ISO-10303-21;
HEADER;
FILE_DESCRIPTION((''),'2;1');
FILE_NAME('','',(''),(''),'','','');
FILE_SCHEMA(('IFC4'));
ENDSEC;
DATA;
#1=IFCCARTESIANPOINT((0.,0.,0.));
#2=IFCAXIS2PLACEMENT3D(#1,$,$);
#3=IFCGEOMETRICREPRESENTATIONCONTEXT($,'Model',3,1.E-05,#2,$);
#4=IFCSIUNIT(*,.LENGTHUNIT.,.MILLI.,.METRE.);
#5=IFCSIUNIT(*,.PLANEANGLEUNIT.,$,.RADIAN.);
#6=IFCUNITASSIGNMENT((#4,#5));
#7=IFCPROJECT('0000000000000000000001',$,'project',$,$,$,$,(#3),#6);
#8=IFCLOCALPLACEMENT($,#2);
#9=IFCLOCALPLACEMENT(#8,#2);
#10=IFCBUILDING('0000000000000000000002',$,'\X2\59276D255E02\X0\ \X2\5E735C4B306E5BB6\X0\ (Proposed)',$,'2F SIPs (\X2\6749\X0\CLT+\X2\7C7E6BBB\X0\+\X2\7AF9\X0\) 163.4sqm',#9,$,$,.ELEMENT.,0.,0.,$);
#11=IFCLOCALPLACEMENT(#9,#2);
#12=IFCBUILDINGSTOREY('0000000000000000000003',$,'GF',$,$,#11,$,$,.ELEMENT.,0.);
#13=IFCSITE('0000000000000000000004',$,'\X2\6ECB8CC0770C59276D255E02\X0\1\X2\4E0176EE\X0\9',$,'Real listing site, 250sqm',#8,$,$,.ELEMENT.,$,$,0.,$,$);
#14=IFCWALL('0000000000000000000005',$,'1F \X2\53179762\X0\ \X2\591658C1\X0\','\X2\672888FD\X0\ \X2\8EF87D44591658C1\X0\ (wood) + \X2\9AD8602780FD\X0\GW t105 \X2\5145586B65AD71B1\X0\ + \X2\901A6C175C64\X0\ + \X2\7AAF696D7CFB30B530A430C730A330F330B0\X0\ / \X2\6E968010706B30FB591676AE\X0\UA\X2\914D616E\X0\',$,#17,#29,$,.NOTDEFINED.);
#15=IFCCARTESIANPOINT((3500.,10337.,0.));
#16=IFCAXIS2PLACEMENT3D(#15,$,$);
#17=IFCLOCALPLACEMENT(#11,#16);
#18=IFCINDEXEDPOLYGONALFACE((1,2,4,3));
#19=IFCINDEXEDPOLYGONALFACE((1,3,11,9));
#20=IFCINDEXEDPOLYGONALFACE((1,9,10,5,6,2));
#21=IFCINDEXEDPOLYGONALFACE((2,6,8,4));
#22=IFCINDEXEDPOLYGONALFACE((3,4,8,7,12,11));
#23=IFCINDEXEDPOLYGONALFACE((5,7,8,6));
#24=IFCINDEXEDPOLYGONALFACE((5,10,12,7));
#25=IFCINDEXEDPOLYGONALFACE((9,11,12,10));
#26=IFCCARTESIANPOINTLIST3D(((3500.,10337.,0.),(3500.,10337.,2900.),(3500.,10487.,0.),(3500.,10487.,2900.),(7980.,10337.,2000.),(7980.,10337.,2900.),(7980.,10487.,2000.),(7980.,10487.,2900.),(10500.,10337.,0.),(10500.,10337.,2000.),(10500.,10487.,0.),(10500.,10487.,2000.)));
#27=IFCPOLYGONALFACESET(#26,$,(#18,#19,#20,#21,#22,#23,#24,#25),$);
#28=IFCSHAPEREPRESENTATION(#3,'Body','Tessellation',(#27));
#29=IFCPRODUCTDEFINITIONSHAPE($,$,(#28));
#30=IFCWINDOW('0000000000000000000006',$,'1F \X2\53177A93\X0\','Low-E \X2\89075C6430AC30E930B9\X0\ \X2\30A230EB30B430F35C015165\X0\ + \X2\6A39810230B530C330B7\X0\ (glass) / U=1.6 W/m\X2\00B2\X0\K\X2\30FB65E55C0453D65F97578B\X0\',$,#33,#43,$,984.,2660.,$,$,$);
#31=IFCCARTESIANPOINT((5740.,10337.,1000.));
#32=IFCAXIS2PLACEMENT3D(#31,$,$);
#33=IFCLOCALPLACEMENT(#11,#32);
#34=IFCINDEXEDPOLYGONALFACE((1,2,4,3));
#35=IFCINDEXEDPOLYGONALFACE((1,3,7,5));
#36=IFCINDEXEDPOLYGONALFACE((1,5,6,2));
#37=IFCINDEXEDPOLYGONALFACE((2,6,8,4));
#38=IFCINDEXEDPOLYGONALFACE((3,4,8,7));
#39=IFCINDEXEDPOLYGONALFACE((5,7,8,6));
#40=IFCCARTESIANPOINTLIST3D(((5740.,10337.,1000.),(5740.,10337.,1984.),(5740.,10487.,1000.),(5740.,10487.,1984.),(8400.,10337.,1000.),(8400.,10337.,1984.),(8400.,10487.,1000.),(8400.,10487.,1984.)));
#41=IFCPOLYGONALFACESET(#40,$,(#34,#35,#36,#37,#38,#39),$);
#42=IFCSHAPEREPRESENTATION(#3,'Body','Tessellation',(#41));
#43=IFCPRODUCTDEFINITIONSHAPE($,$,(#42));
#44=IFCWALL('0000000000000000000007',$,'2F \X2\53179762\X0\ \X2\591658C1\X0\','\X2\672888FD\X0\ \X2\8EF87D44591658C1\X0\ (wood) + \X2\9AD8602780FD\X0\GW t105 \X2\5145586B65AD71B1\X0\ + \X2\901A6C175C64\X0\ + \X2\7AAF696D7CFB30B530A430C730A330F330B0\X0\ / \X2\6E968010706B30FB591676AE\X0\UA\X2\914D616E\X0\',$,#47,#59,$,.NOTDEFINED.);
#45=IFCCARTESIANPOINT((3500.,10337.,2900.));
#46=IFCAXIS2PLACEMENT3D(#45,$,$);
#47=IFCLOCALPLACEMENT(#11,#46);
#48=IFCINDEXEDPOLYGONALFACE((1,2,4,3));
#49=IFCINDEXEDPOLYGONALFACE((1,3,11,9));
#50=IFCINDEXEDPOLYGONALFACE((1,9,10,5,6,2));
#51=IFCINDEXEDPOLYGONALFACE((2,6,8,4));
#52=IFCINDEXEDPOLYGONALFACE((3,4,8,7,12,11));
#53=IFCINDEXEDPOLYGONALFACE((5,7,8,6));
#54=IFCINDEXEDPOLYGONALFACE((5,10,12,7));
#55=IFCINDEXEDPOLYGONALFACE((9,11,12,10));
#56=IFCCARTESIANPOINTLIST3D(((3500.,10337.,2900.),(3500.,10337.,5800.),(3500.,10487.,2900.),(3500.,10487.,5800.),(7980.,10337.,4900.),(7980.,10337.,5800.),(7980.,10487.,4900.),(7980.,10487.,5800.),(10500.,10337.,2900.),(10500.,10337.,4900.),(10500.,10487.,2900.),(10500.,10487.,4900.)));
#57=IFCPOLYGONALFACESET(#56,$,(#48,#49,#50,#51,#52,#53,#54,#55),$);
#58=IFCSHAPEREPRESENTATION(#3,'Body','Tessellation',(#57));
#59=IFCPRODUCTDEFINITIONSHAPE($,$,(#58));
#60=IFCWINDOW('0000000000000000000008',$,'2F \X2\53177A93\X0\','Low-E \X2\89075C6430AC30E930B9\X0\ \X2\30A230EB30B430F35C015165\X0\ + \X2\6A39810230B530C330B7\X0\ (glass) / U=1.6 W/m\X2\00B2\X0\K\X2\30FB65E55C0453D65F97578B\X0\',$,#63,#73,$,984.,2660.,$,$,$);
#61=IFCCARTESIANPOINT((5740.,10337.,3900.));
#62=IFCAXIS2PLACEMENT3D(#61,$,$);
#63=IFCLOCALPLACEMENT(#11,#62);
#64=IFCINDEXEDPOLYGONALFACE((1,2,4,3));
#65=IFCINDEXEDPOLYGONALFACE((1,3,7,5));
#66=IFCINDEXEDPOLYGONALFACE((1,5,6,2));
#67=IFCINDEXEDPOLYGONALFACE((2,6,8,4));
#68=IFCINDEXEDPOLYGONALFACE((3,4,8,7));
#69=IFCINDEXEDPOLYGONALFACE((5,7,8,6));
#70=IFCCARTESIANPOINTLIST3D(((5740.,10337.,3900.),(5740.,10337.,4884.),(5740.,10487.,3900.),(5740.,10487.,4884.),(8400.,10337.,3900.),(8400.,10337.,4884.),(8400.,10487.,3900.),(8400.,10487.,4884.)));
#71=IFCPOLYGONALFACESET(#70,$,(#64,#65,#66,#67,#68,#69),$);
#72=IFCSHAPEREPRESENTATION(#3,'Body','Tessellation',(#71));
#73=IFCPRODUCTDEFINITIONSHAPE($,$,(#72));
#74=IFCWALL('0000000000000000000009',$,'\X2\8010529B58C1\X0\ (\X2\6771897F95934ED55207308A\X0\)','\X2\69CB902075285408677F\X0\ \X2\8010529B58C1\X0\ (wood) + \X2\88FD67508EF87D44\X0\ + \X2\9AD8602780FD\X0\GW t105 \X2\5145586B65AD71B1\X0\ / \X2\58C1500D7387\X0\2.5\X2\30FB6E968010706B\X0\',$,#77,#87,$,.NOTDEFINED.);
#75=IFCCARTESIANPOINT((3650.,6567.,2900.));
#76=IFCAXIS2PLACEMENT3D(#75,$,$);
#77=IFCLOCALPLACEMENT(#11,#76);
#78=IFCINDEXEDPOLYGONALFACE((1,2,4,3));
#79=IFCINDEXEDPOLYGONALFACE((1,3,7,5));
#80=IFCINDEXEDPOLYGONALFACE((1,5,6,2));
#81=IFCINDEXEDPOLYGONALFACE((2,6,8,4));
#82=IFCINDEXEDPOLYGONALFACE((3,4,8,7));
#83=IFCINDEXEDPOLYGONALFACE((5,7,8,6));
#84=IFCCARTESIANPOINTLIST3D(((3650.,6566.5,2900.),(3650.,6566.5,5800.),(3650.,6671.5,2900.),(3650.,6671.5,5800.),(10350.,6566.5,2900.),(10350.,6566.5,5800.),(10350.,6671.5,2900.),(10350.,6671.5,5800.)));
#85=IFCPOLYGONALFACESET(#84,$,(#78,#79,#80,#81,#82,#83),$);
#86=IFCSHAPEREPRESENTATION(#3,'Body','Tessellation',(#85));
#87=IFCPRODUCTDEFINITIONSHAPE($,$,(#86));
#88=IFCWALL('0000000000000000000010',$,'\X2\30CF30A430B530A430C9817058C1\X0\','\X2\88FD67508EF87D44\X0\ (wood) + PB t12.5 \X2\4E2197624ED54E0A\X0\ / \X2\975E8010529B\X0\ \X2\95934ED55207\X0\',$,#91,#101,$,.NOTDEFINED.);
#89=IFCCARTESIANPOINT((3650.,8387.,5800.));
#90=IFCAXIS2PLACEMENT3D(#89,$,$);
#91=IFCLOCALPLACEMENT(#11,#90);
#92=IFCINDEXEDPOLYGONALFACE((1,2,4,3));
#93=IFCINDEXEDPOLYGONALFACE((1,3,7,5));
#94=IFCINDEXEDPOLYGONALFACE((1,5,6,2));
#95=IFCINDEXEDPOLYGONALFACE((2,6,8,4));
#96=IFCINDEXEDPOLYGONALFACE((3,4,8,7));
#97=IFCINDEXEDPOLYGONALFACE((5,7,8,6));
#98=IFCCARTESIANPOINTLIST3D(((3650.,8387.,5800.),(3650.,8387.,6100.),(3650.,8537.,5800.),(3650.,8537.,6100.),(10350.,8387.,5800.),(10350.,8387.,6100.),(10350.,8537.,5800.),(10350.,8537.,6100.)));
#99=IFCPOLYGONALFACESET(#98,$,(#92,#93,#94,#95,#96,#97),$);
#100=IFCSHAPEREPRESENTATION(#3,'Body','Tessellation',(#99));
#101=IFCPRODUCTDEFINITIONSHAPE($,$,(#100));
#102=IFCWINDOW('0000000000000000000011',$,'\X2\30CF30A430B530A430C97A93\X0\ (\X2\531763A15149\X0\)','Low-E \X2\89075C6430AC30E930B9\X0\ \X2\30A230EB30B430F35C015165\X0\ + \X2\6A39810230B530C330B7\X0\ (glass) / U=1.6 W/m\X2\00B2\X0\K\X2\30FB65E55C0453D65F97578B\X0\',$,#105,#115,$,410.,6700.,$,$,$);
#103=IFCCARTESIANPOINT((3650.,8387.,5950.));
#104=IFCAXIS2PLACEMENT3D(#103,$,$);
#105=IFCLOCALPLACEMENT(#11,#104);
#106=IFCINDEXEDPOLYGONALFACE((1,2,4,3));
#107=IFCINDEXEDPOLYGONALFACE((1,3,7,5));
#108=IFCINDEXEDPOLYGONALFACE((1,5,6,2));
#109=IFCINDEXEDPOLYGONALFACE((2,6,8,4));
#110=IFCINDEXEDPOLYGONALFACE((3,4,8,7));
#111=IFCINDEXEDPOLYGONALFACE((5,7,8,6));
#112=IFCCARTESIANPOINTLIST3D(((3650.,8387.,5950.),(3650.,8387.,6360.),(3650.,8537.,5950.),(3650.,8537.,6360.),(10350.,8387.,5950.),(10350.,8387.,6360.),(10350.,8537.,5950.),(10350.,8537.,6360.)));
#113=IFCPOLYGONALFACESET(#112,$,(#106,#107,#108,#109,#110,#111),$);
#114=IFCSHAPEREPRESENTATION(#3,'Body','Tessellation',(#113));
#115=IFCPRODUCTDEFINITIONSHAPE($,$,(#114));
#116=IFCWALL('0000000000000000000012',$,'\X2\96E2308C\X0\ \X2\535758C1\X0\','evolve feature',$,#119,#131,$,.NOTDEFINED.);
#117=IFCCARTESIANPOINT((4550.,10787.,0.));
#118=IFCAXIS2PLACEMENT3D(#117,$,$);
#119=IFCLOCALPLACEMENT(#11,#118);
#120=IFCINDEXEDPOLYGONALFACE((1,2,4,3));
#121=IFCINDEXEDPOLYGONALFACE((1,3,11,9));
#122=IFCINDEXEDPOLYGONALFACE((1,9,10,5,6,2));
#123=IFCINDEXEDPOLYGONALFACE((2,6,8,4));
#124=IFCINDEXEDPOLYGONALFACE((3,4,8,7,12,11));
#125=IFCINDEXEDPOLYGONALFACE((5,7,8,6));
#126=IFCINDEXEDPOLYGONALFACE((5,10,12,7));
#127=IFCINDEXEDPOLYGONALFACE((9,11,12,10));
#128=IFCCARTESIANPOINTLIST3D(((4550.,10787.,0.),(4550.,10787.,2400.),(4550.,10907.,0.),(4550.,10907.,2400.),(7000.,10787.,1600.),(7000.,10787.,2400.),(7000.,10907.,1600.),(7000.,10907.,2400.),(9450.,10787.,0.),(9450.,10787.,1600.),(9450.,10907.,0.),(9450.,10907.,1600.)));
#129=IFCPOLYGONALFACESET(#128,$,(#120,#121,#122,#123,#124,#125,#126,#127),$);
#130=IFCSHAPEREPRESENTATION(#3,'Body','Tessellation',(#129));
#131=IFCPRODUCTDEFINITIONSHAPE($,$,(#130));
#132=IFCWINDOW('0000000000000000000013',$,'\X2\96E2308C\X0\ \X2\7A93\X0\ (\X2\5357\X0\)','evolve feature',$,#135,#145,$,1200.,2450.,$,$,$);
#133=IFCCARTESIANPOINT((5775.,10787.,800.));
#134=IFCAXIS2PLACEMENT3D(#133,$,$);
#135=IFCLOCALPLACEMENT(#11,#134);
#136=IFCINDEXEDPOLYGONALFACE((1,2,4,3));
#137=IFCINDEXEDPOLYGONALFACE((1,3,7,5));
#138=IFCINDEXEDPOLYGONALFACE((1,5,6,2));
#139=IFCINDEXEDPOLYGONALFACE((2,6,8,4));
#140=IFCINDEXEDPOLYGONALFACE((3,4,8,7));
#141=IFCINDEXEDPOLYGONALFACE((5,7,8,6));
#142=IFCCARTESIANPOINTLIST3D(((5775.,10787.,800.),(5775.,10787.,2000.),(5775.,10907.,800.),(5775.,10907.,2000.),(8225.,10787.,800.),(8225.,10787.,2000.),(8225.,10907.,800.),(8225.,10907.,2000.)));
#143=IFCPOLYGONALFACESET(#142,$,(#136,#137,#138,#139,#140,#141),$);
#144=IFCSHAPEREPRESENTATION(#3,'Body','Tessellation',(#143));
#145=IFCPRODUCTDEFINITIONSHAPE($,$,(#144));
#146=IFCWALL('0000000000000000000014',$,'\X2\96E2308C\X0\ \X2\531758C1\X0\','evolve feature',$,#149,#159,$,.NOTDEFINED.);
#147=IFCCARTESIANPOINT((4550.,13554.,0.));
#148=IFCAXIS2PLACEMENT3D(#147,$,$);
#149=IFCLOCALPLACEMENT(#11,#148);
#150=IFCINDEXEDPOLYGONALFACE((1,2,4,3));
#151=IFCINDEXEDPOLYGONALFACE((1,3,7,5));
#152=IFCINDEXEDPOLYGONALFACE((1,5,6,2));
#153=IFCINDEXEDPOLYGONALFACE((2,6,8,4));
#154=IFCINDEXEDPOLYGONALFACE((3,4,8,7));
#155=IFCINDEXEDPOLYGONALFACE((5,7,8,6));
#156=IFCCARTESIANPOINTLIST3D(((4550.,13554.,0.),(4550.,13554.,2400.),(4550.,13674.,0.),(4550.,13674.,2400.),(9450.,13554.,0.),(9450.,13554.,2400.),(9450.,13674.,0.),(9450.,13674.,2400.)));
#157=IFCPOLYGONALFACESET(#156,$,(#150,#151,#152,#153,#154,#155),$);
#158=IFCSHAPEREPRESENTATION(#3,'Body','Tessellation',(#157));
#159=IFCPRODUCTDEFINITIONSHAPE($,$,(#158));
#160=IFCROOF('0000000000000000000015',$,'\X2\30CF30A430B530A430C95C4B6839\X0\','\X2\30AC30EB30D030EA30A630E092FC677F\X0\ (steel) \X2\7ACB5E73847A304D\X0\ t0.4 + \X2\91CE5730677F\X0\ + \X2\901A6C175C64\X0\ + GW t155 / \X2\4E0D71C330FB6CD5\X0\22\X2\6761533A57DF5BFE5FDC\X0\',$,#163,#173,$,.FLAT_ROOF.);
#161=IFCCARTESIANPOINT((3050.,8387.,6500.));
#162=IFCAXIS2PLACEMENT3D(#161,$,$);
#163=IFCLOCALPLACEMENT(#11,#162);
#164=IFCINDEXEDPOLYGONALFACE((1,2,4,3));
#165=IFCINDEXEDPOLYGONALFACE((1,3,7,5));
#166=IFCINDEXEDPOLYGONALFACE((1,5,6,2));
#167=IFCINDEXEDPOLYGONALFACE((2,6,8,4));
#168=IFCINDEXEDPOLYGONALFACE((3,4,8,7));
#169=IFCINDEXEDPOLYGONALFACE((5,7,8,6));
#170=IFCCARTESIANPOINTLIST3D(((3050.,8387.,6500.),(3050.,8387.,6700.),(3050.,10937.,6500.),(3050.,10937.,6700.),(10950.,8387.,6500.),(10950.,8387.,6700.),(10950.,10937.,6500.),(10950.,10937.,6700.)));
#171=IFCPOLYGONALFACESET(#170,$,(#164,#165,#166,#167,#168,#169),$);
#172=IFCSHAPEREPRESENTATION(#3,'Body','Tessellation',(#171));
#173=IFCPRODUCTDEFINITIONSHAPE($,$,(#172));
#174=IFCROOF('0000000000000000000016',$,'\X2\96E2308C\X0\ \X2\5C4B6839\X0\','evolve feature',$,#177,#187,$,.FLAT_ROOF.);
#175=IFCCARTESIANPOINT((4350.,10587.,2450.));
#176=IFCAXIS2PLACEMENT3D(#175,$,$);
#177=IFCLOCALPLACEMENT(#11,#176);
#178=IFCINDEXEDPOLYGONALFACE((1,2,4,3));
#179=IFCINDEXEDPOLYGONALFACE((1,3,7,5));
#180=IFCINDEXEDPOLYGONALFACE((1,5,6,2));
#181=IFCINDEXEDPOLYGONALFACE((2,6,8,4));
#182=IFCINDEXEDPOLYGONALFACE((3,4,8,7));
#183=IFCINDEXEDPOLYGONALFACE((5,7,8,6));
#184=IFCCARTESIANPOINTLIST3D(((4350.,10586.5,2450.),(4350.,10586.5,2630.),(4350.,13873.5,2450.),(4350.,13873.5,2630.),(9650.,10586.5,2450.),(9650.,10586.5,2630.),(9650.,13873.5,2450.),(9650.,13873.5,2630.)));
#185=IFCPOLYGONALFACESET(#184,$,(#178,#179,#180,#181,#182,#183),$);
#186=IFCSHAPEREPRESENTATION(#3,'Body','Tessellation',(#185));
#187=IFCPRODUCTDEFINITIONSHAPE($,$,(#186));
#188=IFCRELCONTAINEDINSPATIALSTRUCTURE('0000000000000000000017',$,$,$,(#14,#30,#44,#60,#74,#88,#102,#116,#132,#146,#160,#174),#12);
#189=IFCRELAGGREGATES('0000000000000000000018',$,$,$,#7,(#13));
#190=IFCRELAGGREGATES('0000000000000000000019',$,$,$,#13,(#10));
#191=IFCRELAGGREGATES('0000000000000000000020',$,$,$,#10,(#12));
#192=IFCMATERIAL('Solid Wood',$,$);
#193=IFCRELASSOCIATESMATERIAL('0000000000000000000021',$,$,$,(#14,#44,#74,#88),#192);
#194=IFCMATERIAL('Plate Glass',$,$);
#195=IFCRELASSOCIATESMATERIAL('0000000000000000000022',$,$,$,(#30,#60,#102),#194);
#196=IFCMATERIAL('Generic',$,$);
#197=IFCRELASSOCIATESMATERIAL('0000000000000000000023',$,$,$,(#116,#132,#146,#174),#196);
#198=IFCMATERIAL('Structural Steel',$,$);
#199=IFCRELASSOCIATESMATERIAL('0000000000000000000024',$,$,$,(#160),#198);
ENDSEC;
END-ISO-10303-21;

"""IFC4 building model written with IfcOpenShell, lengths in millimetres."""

from ifc_helpers import new_model, si_unit, frame, frame_2d, origin, place, context, project, spatial, rectangle, extrude, material, element, fill, save


model = new_model("IFC4")

# Units and contexts
model_context = context("Model", 3, precision=1e-05, world=origin())
ifc_project = project(units=[si_unit("LENGTHUNIT", "METRE", prefix="MILLI"), si_unit("PLANEANGLEUNIT", "RADIAN")], contexts=[model_context])

# Site, building, storey
site_placement = place(None, origin())
site = spatial("IfcSite", under=ifc_project, at=site_placement, Name="滋賀県大津市1丁目9", ObjectType="Real listing site, 250sqm", CompositionType="ELEMENT", RefElevation=0.0)
building_placement = place(site_placement, origin())
building = spatial("IfcBuilding", under=site, at=building_placement, Name="大津市 平屋の家 (Proposed)", ObjectType="2F SIPs (杉CLT+籾殻+竹) 163.4sqm", CompositionType="ELEMENT", ElevationOfRefHeight=0.0, ElevationOfTerrain=0.0)
storey_placement = place(building_placement, origin())
storey = spatial("IfcBuildingStorey", under=building, at=storey_placement, Name="GF", CompositionType="ELEMENT", Elevation=0.0)

# Shared definitions
ifc_material_1 = material(Name="Generic")

# Wall, opening, window
ifc_material_2 = material(Name="Solid Wood")
wall_1_placement = place(storey_placement, frame((3500.0, 10337.0, 0.0)))
wall_1 = element("IfcWall", 1, at=wall_1_placement, inside=storey, material=ifc_material_2, Name="1F 北面 外壁", Description="木製 軸組外壁 (wood) + 高性能GW t105 充填断熱 + 通気層 + 窯業系サイディング / 準耐火・外皮UA配慮", PredefinedType="NOTDEFINED", context=model_context, shape_type="SweptSolid", body=[
    extrude(rectangle(XDim=7000.0, YDim=150.0, at=frame_2d((3500.0, 75.0))), frame((3500.0, 10337.0, 0.0)), (0.0, 0.0, 1.0), 2900.0),
])
opening_1_placement = place(storey_placement, frame((5740.0, 10337.0, 1000.0)))
opening_1 = element("IfcOpeningElement", 2, at=opening_1_placement, cuts=wall_1, PredefinedType="NOTDEFINED", context=model_context, shape_type="SweptSolid", body=[
    extrude(rectangle(XDim=2660.0, YDim=150.0, at=frame_2d((1330.0, 75.0))), frame((5740.0, 10337.0, 1000.0)), (0.0, 0.0, 1.0), 984.0),
])
ifc_material_3 = material(Name="Plate Glass")
window_1_placement = place(storey_placement, frame((5740.0, 10337.0, 1000.0)))
window_1 = element("IfcWindow", 3, at=window_1_placement, inside=storey, material=ifc_material_3, Name="1F 北窓", Description="Low-E 複層ガラス アルゴン封入 + 樹脂サッシ (glass) / U=1.6 W/m²K・日射取得型", OverallHeight=984.0, OverallWidth=2660.0, context=model_context, shape_type="SweptSolid", body=[
    extrude(rectangle(XDim=2660.0, YDim=150.0, at=frame_2d((1330.0, 75.0))), frame((5740.0, 10337.0, 1000.0)), (0.0, 0.0, 1.0), 984.0),
])
fill(opening_1, window_1)

# Wall, opening, window
wall_2_placement = place(storey_placement, frame((3500.0, 10337.0, 2900.0)))
wall_2 = element("IfcWall", 4, at=wall_2_placement, inside=storey, material=ifc_material_2, Name="2F 北面 外壁", Description="木製 軸組外壁 (wood) + 高性能GW t105 充填断熱 + 通気層 + 窯業系サイディング / 準耐火・外皮UA配慮", PredefinedType="NOTDEFINED", context=model_context, shape_type="SweptSolid", body=[
    extrude(rectangle(XDim=7000.0, YDim=150.0, at=frame_2d((3500.0, 75.0))), frame((3500.0, 10337.0, 2900.0)), (0.0, 0.0, 1.0), 2900.0),
])
opening_2_placement = place(storey_placement, frame((5740.0, 10337.0, 3900.0)))
opening_2 = element("IfcOpeningElement", 5, at=opening_2_placement, cuts=wall_2, PredefinedType="NOTDEFINED", context=model_context, shape_type="SweptSolid", body=[
    extrude(rectangle(XDim=2660.0, YDim=150.0, at=frame_2d((1330.0, 75.0))), frame((5740.0, 10337.0, 3900.0)), (0.0, 0.0, 1.0), 984.0),
])
window_2_placement = place(storey_placement, frame((5740.0, 10337.0, 3900.0)))
window_2 = element("IfcWindow", 6, at=window_2_placement, inside=storey, material=ifc_material_3, Name="2F 北窓", Description="Low-E 複層ガラス アルゴン封入 + 樹脂サッシ (glass) / U=1.6 W/m²K・日射取得型", OverallHeight=984.0, OverallWidth=2660.0, context=model_context, shape_type="SweptSolid", body=[
    extrude(rectangle(XDim=2660.0, YDim=150.0, at=frame_2d((1330.0, 75.0))), frame((5740.0, 10337.0, 3900.0)), (0.0, 0.0, 1.0), 984.0),
])
fill(opening_2, window_2)

# Wall
wall_3_placement = place(storey_placement, frame((3650.0, 6567.0, 2900.0)))
element("IfcWall", 7, at=wall_3_placement, inside=storey, material=ifc_material_2, Name="耐力壁 (東西間仕切り)", Description="構造用合板 耐力壁 (wood) + 製材軸組 + 高性能GW t105 充填断熱 / 壁倍率2.5・準耐火", PredefinedType="NOTDEFINED", context=model_context, shape_type="SweptSolid", body=[
    extrude(rectangle(XDim=6700.0, YDim=105.0, at=frame_2d((3350.0, 52.0))), frame((3650.0, 6567.0, 2900.0)), (0.0, 0.0, 1.0), 2900.0),
])

# Walls, openings, windows
wall_4_placement = place(storey_placement, frame((3650.0, 8387.0, 5800.0)))
wall_4 = element("IfcWall", 8, at=wall_4_placement, inside=storey, material=ifc_material_2, Name="ハイサイド腰壁", Description="製材軸組 (wood) + PB t12.5 両面仕上 / 非耐力 間仕切", PredefinedType="NOTDEFINED", context=model_context, shape_type="SweptSolid", body=[
    extrude(rectangle(XDim=6700.0, YDim=150.0, at=frame_2d((3350.0, 75.0))), frame((3650.0, 8387.0, 5800.0)), (0.0, 0.0, 1.0), 700.0),
])
opening_3_placement = place(storey_placement, frame((3650.0, 8387.0, 5950.0)))
opening_3 = element("IfcOpeningElement", 9, at=opening_3_placement, cuts=wall_4, PredefinedType="NOTDEFINED", context=model_context, shape_type="SweptSolid", body=[
    extrude(rectangle(XDim=6700.0, YDim=150.0, at=frame_2d((3350.0, 75.0))), frame((3650.0, 8387.0, 5950.0)), (0.0, 0.0, 1.0), 410.0),
])
window_3_placement = place(storey_placement, frame((3650.0, 8387.0, 5950.0)))
window_3 = element("IfcWindow", 10, at=window_3_placement, inside=storey, material=ifc_material_3, Name="ハイサイド窓 (北採光)", Description="Low-E 複層ガラス アルゴン封入 + 樹脂サッシ (glass) / U=1.6 W/m²K・日射取得型", OverallHeight=410.0, OverallWidth=6700.0, context=model_context, shape_type="SweptSolid", body=[
    extrude(rectangle(XDim=6700.0, YDim=150.0, at=frame_2d((3350.0, 75.0))), frame((3650.0, 8387.0, 5950.0)), (0.0, 0.0, 1.0), 410.0),
])
fill(opening_3, window_3)
wall_5_placement = place(storey_placement, frame((4550.0, 10787.0, 0.0)))
wall_5 = element("IfcWall", 11, at=wall_5_placement, inside=storey, material=ifc_material_1, Name="離れ 南壁", Description="evolve feature", PredefinedType="NOTDEFINED", context=model_context, shape_type="SweptSolid", body=[
    extrude(rectangle(XDim=4900.0, YDim=120.0, at=frame_2d((2450.0, 60.0))), frame((4550.0, 10787.0, 0.0)), (0.0, 0.0, 1.0), 2400.0),
])
opening_4_placement = place(storey_placement, frame((5775.0, 10787.0, 800.0)))
opening_4 = element("IfcOpeningElement", 12, at=opening_4_placement, cuts=wall_5, PredefinedType="NOTDEFINED", context=model_context, shape_type="SweptSolid", body=[
    extrude(rectangle(XDim=2450.0, YDim=120.0, at=frame_2d((1225.0, 60.0))), frame((5775.0, 10787.0, 800.0)), (0.0, 0.0, 1.0), 1200.0),
])
window_4_placement = place(storey_placement, frame((5775.0, 10787.0, 800.0)))
window_4 = element("IfcWindow", 13, at=window_4_placement, inside=storey, material=ifc_material_1, Name="離れ 窓 (南)", Description="evolve feature", OverallHeight=1200.0, OverallWidth=2450.0, context=model_context, shape_type="SweptSolid", body=[
    extrude(rectangle(XDim=2450.0, YDim=120.0, at=frame_2d((1225.0, 60.0))), frame((5775.0, 10787.0, 800.0)), (0.0, 0.0, 1.0), 1200.0),
])
fill(opening_4, window_4)

# Wall
wall_6_placement = place(storey_placement, frame((4550.0, 13554.0, 0.0)))
element("IfcWall", 14, at=wall_6_placement, inside=storey, material=ifc_material_1, Name="離れ 北壁", Description="evolve feature", PredefinedType="NOTDEFINED", context=model_context, shape_type="SweptSolid", body=[
    extrude(rectangle(XDim=4900.0, YDim=120.0, at=frame_2d((2450.0, 60.0))), frame((4550.0, 13554.0, 0.0)), (0.0, 0.0, 1.0), 2400.0),
])

# Roofs
ifc_material_4 = material(Name="Structural Steel")
roof_1_placement = place(storey_placement, frame((3050.0, 8387.0, 6500.0)))
element("IfcRoof", 15, at=roof_1_placement, inside=storey, material=ifc_material_4, Name="ハイサイド屋根", Description="ガルバリウム鋼板 (steel) 立平葺き t0.4 + 野地板 + 通気層 + GW t155 / 不燃・法22条区域対応", PredefinedType="FLAT_ROOF", context=model_context, shape_type="SweptSolid", body=[
    extrude(rectangle(XDim=7900.0, YDim=2550.0, at=frame_2d((3950.0, 1275.0))), frame((3050.0, 8387.0, 6500.0)), (0.0, 0.0, 1.0), 200.0),
])
roof_2_placement = place(storey_placement, frame((4350.0, 10587.0, 2450.0)))
element("IfcRoof", 16, at=roof_2_placement, inside=storey, material=ifc_material_1, Name="離れ 屋根", Description="evolve feature", PredefinedType="FLAT_ROOF", context=model_context, shape_type="SweptSolid", body=[
    extrude(rectangle(XDim=5300.0, YDim=3287.0, at=frame_2d((2650.0, 1643.0))), frame((4350.0, 10587.0, 2450.0)), (0.0, 0.0, 1.0), 180.0),
])

save(model, "model.ifc")
